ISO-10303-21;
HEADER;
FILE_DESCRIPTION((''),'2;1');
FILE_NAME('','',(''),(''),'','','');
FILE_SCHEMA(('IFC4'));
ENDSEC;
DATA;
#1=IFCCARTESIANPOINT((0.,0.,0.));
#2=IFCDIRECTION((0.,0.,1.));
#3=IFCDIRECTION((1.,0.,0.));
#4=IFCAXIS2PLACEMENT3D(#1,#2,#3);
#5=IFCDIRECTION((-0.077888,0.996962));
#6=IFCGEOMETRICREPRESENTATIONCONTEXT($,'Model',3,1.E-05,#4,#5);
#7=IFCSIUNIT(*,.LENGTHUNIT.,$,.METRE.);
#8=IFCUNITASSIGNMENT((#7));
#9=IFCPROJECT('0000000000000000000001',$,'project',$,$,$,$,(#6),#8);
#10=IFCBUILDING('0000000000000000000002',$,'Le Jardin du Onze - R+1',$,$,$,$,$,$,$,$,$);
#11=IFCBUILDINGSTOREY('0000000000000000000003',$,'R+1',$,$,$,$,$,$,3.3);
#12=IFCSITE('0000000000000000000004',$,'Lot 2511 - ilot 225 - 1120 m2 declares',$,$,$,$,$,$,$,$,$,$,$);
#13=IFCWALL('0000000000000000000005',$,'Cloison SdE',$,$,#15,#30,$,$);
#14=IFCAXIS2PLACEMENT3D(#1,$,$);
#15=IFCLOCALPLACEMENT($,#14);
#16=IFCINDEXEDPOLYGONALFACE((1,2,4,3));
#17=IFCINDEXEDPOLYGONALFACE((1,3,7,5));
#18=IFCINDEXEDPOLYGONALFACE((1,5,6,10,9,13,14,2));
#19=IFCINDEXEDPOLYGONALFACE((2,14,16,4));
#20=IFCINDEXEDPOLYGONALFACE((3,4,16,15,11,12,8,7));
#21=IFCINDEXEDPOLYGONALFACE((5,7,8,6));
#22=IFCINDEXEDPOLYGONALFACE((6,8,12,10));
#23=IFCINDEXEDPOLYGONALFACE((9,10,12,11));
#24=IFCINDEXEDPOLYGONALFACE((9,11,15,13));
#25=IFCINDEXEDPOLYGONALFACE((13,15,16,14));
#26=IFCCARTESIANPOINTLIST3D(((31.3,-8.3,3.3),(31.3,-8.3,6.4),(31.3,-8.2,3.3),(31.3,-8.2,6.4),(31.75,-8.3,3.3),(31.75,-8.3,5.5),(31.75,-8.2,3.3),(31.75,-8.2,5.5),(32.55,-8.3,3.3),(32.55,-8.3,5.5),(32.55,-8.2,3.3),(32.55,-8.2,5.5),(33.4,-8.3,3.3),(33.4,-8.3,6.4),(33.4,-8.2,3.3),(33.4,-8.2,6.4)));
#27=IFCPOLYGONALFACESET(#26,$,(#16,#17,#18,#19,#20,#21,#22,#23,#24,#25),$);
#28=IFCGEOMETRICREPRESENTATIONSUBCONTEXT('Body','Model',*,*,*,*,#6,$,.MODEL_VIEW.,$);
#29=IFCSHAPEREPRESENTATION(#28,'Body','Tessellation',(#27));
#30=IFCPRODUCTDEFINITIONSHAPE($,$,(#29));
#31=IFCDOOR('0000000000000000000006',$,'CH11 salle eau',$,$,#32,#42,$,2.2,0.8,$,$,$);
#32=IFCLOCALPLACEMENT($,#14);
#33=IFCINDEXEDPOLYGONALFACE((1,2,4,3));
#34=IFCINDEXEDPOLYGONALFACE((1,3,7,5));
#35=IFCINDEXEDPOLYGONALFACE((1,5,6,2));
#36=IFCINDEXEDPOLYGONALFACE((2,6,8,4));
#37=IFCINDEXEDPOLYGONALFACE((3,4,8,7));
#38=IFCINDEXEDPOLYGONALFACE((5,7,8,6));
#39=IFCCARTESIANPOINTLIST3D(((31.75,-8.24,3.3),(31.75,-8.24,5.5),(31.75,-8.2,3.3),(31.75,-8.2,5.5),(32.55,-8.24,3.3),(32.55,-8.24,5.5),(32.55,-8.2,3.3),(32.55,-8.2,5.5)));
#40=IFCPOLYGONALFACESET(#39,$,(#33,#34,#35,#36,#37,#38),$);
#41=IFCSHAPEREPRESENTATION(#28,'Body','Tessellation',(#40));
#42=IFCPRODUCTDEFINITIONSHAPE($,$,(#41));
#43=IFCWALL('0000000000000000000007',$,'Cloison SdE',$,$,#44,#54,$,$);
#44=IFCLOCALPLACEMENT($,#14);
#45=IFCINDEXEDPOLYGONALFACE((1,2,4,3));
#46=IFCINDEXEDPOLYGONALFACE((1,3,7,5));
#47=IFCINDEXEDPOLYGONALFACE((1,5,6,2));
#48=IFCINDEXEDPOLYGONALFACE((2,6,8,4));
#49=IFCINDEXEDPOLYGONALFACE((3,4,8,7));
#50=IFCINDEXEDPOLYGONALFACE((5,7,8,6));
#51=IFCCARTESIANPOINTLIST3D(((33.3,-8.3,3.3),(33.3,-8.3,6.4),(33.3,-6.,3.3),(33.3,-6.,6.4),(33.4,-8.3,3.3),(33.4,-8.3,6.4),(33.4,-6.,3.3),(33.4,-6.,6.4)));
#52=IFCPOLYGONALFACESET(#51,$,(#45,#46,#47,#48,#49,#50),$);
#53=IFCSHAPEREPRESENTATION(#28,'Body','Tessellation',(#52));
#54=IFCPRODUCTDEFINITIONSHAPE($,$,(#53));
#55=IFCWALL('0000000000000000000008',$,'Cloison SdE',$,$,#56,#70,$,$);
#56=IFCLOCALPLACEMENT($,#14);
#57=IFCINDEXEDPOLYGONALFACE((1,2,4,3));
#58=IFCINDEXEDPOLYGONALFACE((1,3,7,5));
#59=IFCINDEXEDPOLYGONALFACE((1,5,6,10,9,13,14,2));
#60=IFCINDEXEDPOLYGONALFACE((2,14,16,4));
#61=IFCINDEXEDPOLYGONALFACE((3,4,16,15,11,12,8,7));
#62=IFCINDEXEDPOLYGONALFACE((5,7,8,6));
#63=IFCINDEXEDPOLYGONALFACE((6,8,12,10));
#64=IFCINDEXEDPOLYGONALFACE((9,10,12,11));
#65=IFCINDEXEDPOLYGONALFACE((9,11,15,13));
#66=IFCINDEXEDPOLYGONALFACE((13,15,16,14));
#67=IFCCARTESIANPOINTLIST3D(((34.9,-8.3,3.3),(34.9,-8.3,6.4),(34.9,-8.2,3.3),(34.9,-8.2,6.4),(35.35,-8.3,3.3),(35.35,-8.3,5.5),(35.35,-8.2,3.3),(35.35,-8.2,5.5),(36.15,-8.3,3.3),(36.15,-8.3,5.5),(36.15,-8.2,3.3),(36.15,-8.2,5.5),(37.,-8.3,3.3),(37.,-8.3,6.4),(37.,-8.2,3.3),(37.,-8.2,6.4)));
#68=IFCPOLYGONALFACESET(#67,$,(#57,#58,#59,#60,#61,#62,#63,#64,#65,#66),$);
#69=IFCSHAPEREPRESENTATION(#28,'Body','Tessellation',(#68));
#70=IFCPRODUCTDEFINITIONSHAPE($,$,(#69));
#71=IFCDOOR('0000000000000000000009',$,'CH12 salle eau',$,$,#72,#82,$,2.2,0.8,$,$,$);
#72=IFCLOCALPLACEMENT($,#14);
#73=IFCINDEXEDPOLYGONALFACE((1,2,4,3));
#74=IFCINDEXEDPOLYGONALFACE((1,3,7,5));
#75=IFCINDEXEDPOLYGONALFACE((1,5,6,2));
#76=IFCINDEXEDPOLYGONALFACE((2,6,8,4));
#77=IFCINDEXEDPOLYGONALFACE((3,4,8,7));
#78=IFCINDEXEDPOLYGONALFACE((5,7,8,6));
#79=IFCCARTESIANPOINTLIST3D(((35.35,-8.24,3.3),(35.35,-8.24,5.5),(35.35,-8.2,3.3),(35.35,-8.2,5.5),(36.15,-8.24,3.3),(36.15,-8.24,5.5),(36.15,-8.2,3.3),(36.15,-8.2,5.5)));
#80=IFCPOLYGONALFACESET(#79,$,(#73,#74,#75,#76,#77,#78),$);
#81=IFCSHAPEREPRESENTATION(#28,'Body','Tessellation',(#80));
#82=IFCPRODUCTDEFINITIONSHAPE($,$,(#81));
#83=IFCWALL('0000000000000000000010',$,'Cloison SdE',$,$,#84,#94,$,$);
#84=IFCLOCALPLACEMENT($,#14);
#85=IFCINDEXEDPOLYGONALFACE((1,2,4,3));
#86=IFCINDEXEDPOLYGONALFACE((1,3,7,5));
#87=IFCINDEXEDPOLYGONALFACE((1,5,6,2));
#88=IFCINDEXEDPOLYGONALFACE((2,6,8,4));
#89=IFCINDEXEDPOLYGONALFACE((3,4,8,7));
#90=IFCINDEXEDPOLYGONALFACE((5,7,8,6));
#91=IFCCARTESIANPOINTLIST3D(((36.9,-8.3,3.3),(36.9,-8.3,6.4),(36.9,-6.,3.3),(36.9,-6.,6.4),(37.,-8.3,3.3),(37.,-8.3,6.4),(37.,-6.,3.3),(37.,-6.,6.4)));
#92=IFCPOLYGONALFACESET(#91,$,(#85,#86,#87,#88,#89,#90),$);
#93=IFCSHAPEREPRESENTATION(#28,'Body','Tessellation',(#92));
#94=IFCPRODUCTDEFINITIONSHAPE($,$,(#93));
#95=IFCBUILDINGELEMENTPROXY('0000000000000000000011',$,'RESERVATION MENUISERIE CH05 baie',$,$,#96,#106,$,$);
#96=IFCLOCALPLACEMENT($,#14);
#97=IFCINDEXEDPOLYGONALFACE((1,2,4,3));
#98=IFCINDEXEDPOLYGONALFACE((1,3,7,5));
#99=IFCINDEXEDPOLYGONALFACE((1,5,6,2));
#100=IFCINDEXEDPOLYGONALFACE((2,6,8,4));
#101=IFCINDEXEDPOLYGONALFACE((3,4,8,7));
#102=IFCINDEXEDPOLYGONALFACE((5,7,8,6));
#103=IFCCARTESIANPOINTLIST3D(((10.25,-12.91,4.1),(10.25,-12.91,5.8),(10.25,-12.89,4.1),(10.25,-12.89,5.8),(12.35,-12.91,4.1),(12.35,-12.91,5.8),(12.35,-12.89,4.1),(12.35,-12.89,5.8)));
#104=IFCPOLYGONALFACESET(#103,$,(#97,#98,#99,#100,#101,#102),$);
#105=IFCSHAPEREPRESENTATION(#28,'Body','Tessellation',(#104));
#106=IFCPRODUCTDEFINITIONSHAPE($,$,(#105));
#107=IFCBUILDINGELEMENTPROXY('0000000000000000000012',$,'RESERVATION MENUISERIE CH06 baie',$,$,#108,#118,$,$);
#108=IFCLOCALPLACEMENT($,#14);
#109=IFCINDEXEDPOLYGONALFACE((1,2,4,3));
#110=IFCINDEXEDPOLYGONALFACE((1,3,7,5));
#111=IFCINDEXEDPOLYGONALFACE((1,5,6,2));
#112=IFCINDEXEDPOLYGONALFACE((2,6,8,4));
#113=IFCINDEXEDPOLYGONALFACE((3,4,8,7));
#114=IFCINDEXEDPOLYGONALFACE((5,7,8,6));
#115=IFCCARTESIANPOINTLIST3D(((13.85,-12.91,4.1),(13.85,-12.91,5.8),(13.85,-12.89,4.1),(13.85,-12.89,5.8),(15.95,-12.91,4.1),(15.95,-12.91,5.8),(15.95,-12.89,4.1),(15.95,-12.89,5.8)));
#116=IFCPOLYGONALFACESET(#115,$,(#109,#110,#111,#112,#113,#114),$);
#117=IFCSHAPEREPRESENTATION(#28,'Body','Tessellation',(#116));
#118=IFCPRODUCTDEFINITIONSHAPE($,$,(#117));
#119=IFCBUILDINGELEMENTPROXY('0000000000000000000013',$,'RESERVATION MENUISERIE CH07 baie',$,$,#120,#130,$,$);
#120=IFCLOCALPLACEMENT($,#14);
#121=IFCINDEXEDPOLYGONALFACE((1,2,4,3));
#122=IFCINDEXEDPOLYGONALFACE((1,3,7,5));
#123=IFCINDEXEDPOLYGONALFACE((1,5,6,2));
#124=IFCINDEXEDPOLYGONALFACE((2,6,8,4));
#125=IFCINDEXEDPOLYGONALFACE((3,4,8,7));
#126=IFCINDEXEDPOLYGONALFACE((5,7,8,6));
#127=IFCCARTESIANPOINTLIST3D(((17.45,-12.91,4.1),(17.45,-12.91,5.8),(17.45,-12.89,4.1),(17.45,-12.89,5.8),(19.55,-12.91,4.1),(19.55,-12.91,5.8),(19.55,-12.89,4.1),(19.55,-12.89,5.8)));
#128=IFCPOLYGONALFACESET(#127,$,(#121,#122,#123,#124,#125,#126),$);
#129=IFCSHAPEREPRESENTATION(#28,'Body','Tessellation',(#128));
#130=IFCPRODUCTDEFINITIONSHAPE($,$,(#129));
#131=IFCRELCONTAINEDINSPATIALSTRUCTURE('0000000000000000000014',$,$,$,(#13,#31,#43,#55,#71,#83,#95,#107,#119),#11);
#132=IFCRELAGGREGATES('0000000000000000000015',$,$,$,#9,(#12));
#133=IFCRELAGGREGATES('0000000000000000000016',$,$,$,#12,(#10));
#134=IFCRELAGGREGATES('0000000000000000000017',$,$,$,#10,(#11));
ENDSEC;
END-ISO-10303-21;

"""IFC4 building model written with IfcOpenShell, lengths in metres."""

from ifc_helpers import new_model, si_unit, direction, frame, origin_with_axes, place, context, subcontext, project, spatial, polyline, outline, extrude, element, fill, save


model = new_model("IFC4")

# Units and contexts
model_context = context("Model", 3, precision=1e-05, world=origin_with_axes(), true_north=direction((-0.077888, 0.996962)))
body_context = subcontext(model_context, "Body", "Model", "MODEL_VIEW")
ifc_project = project(units=[si_unit("LENGTHUNIT", "METRE")], contexts=[model_context])

# Site, building, storey
site = spatial("IfcSite", under=ifc_project, Name="Lot 2511 - ilot 225 - 1120 m2 declares")
building = spatial("IfcBuilding", under=site, Name="Le Jardin du Onze - R+1")
storey = spatial("IfcBuildingStorey", under=building, Name="R+1", Elevation=3.3)

# Wall, opening, door
wall_1_placement = place(None, origin_with_axes())
wall_1 = element("IfcWall", 1, at=wall_1_placement, inside=storey, Name="Cloison SdE", context=body_context, shape_type="SweptSolid", body=[
    extrude(outline(polyline([(33.4, -8.3), (33.4, -8.2), (31.3, -8.2), (31.3, -8.3), (33.4, -8.3)])), frame((0.0, 0.0, 3.3)), (0.0, 0.0, 1.0), 3.1),
])
opening_1_placement = place(None, origin_with_axes())
opening_1 = element("IfcOpeningElement", 2, at=opening_1_placement, cuts=wall_1, context=body_context, shape_type="SweptSolid", body=[
    extrude(outline(polyline([(32.55, -8.34), (32.55, -8.06), (31.75, -8.06), (31.75, -8.34), (32.55, -8.34)])), frame((0.0, 0.0, 3.3)), (0.0, 0.0, 1.0), 2.2),
])
door_1_placement = place(None, origin_with_axes())
door_1 = element("IfcDoor", 3, at=door_1_placement, inside=storey, Name="CH11 salle eau", OverallHeight=2.2, OverallWidth=0.8, context=body_context, shape_type="SweptSolid", body=[
    extrude(outline(polyline([(32.55, -8.24), (32.55, -8.2), (31.75, -8.2), (31.75, -8.24), (32.55, -8.24)])), frame((0.0, 0.0, 3.3)), (0.0, 0.0, 1.0), 2.2),
])
fill(opening_1, door_1)

# Wall
wall_2_placement = place(None, origin_with_axes())
element("IfcWall", 4, at=wall_2_placement, inside=storey, Name="Cloison SdE", context=body_context, shape_type="SweptSolid", body=[
    extrude(outline(polyline([(33.4, -8.3), (33.4, -6.0), (33.3, -6.0), (33.3, -8.3), (33.4, -8.3)])), frame((0.0, 0.0, 3.3)), (0.0, 0.0, 1.0), 3.1),
])

# Wall, opening, door
wall_3_placement = place(None, origin_with_axes())
wall_3 = element("IfcWall", 5, at=wall_3_placement, inside=storey, Name="Cloison SdE", context=body_context, shape_type="SweptSolid", body=[
    extrude(outline(polyline([(37.0, -8.3), (37.0, -8.2), (34.9, -8.2), (34.9, -8.3), (37.0, -8.3)])), frame((0.0, 0.0, 3.3)), (0.0, 0.0, 1.0), 3.1),
])
opening_2_placement = place(None, origin_with_axes())
opening_2 = element("IfcOpeningElement", 6, at=opening_2_placement, cuts=wall_3, context=body_context, shape_type="SweptSolid", body=[
    extrude(outline(polyline([(36.15, -8.34), (36.15, -8.06), (35.35, -8.06), (35.35, -8.34), (36.15, -8.34)])), frame((0.0, 0.0, 3.3)), (0.0, 0.0, 1.0), 2.2),
])
door_2_placement = place(None, origin_with_axes())
door_2 = element("IfcDoor", 7, at=door_2_placement, inside=storey, Name="CH12 salle eau", OverallHeight=2.2, OverallWidth=0.8, context=body_context, shape_type="SweptSolid", body=[
    extrude(outline(polyline([(36.15, -8.24), (36.15, -8.2), (35.35, -8.2), (35.35, -8.24), (36.15, -8.24)])), frame((0.0, 0.0, 3.3)), (0.0, 0.0, 1.0), 2.2),
])
fill(opening_2, door_2)

# Wall
wall_4_placement = place(None, origin_with_axes())
element("IfcWall", 8, at=wall_4_placement, inside=storey, Name="Cloison SdE", context=body_context, shape_type="SweptSolid", body=[
    extrude(outline(polyline([(37.0, -8.3), (37.0, -6.0), (36.9, -6.0), (36.9, -8.3), (37.0, -8.3)])), frame((0.0, 0.0, 3.3)), (0.0, 0.0, 1.0), 3.1),
])

# Building element proxies
proxy_1_placement = place(None, origin_with_axes())
element("IfcBuildingElementProxy", 9, at=proxy_1_placement, inside=storey, Name="RESERVATION MENUISERIE CH05 baie", context=body_context, shape_type="SweptSolid", body=[
    extrude(outline(polyline([(12.35, -12.91), (12.35, -12.89), (10.25, -12.89), (10.25, -12.91), (12.35, -12.91)])), frame((0.0, 0.0, 4.1)), (0.0, 0.0, 1.0), 1.7),
])
proxy_2_placement = place(None, origin_with_axes())
element("IfcBuildingElementProxy", 10, at=proxy_2_placement, inside=storey, Name="RESERVATION MENUISERIE CH06 baie", context=body_context, shape_type="SweptSolid", body=[
    extrude(outline(polyline([(15.95, -12.91), (15.95, -12.89), (13.85, -12.89), (13.85, -12.91), (15.95, -12.91)])), frame((0.0, 0.0, 4.1)), (0.0, 0.0, 1.0), 1.7),
])
proxy_3_placement = place(None, origin_with_axes())
element("IfcBuildingElementProxy", 11, at=proxy_3_placement, inside=storey, Name="RESERVATION MENUISERIE CH07 baie", context=body_context, shape_type="SweptSolid", body=[
    extrude(outline(polyline([(19.55, -12.91), (19.55, -12.89), (17.45, -12.89), (17.45, -12.91), (19.55, -12.91)])), frame((0.0, 0.0, 4.1)), (0.0, 0.0, 1.0), 1.7),
])

save(model, "model.ifc")
